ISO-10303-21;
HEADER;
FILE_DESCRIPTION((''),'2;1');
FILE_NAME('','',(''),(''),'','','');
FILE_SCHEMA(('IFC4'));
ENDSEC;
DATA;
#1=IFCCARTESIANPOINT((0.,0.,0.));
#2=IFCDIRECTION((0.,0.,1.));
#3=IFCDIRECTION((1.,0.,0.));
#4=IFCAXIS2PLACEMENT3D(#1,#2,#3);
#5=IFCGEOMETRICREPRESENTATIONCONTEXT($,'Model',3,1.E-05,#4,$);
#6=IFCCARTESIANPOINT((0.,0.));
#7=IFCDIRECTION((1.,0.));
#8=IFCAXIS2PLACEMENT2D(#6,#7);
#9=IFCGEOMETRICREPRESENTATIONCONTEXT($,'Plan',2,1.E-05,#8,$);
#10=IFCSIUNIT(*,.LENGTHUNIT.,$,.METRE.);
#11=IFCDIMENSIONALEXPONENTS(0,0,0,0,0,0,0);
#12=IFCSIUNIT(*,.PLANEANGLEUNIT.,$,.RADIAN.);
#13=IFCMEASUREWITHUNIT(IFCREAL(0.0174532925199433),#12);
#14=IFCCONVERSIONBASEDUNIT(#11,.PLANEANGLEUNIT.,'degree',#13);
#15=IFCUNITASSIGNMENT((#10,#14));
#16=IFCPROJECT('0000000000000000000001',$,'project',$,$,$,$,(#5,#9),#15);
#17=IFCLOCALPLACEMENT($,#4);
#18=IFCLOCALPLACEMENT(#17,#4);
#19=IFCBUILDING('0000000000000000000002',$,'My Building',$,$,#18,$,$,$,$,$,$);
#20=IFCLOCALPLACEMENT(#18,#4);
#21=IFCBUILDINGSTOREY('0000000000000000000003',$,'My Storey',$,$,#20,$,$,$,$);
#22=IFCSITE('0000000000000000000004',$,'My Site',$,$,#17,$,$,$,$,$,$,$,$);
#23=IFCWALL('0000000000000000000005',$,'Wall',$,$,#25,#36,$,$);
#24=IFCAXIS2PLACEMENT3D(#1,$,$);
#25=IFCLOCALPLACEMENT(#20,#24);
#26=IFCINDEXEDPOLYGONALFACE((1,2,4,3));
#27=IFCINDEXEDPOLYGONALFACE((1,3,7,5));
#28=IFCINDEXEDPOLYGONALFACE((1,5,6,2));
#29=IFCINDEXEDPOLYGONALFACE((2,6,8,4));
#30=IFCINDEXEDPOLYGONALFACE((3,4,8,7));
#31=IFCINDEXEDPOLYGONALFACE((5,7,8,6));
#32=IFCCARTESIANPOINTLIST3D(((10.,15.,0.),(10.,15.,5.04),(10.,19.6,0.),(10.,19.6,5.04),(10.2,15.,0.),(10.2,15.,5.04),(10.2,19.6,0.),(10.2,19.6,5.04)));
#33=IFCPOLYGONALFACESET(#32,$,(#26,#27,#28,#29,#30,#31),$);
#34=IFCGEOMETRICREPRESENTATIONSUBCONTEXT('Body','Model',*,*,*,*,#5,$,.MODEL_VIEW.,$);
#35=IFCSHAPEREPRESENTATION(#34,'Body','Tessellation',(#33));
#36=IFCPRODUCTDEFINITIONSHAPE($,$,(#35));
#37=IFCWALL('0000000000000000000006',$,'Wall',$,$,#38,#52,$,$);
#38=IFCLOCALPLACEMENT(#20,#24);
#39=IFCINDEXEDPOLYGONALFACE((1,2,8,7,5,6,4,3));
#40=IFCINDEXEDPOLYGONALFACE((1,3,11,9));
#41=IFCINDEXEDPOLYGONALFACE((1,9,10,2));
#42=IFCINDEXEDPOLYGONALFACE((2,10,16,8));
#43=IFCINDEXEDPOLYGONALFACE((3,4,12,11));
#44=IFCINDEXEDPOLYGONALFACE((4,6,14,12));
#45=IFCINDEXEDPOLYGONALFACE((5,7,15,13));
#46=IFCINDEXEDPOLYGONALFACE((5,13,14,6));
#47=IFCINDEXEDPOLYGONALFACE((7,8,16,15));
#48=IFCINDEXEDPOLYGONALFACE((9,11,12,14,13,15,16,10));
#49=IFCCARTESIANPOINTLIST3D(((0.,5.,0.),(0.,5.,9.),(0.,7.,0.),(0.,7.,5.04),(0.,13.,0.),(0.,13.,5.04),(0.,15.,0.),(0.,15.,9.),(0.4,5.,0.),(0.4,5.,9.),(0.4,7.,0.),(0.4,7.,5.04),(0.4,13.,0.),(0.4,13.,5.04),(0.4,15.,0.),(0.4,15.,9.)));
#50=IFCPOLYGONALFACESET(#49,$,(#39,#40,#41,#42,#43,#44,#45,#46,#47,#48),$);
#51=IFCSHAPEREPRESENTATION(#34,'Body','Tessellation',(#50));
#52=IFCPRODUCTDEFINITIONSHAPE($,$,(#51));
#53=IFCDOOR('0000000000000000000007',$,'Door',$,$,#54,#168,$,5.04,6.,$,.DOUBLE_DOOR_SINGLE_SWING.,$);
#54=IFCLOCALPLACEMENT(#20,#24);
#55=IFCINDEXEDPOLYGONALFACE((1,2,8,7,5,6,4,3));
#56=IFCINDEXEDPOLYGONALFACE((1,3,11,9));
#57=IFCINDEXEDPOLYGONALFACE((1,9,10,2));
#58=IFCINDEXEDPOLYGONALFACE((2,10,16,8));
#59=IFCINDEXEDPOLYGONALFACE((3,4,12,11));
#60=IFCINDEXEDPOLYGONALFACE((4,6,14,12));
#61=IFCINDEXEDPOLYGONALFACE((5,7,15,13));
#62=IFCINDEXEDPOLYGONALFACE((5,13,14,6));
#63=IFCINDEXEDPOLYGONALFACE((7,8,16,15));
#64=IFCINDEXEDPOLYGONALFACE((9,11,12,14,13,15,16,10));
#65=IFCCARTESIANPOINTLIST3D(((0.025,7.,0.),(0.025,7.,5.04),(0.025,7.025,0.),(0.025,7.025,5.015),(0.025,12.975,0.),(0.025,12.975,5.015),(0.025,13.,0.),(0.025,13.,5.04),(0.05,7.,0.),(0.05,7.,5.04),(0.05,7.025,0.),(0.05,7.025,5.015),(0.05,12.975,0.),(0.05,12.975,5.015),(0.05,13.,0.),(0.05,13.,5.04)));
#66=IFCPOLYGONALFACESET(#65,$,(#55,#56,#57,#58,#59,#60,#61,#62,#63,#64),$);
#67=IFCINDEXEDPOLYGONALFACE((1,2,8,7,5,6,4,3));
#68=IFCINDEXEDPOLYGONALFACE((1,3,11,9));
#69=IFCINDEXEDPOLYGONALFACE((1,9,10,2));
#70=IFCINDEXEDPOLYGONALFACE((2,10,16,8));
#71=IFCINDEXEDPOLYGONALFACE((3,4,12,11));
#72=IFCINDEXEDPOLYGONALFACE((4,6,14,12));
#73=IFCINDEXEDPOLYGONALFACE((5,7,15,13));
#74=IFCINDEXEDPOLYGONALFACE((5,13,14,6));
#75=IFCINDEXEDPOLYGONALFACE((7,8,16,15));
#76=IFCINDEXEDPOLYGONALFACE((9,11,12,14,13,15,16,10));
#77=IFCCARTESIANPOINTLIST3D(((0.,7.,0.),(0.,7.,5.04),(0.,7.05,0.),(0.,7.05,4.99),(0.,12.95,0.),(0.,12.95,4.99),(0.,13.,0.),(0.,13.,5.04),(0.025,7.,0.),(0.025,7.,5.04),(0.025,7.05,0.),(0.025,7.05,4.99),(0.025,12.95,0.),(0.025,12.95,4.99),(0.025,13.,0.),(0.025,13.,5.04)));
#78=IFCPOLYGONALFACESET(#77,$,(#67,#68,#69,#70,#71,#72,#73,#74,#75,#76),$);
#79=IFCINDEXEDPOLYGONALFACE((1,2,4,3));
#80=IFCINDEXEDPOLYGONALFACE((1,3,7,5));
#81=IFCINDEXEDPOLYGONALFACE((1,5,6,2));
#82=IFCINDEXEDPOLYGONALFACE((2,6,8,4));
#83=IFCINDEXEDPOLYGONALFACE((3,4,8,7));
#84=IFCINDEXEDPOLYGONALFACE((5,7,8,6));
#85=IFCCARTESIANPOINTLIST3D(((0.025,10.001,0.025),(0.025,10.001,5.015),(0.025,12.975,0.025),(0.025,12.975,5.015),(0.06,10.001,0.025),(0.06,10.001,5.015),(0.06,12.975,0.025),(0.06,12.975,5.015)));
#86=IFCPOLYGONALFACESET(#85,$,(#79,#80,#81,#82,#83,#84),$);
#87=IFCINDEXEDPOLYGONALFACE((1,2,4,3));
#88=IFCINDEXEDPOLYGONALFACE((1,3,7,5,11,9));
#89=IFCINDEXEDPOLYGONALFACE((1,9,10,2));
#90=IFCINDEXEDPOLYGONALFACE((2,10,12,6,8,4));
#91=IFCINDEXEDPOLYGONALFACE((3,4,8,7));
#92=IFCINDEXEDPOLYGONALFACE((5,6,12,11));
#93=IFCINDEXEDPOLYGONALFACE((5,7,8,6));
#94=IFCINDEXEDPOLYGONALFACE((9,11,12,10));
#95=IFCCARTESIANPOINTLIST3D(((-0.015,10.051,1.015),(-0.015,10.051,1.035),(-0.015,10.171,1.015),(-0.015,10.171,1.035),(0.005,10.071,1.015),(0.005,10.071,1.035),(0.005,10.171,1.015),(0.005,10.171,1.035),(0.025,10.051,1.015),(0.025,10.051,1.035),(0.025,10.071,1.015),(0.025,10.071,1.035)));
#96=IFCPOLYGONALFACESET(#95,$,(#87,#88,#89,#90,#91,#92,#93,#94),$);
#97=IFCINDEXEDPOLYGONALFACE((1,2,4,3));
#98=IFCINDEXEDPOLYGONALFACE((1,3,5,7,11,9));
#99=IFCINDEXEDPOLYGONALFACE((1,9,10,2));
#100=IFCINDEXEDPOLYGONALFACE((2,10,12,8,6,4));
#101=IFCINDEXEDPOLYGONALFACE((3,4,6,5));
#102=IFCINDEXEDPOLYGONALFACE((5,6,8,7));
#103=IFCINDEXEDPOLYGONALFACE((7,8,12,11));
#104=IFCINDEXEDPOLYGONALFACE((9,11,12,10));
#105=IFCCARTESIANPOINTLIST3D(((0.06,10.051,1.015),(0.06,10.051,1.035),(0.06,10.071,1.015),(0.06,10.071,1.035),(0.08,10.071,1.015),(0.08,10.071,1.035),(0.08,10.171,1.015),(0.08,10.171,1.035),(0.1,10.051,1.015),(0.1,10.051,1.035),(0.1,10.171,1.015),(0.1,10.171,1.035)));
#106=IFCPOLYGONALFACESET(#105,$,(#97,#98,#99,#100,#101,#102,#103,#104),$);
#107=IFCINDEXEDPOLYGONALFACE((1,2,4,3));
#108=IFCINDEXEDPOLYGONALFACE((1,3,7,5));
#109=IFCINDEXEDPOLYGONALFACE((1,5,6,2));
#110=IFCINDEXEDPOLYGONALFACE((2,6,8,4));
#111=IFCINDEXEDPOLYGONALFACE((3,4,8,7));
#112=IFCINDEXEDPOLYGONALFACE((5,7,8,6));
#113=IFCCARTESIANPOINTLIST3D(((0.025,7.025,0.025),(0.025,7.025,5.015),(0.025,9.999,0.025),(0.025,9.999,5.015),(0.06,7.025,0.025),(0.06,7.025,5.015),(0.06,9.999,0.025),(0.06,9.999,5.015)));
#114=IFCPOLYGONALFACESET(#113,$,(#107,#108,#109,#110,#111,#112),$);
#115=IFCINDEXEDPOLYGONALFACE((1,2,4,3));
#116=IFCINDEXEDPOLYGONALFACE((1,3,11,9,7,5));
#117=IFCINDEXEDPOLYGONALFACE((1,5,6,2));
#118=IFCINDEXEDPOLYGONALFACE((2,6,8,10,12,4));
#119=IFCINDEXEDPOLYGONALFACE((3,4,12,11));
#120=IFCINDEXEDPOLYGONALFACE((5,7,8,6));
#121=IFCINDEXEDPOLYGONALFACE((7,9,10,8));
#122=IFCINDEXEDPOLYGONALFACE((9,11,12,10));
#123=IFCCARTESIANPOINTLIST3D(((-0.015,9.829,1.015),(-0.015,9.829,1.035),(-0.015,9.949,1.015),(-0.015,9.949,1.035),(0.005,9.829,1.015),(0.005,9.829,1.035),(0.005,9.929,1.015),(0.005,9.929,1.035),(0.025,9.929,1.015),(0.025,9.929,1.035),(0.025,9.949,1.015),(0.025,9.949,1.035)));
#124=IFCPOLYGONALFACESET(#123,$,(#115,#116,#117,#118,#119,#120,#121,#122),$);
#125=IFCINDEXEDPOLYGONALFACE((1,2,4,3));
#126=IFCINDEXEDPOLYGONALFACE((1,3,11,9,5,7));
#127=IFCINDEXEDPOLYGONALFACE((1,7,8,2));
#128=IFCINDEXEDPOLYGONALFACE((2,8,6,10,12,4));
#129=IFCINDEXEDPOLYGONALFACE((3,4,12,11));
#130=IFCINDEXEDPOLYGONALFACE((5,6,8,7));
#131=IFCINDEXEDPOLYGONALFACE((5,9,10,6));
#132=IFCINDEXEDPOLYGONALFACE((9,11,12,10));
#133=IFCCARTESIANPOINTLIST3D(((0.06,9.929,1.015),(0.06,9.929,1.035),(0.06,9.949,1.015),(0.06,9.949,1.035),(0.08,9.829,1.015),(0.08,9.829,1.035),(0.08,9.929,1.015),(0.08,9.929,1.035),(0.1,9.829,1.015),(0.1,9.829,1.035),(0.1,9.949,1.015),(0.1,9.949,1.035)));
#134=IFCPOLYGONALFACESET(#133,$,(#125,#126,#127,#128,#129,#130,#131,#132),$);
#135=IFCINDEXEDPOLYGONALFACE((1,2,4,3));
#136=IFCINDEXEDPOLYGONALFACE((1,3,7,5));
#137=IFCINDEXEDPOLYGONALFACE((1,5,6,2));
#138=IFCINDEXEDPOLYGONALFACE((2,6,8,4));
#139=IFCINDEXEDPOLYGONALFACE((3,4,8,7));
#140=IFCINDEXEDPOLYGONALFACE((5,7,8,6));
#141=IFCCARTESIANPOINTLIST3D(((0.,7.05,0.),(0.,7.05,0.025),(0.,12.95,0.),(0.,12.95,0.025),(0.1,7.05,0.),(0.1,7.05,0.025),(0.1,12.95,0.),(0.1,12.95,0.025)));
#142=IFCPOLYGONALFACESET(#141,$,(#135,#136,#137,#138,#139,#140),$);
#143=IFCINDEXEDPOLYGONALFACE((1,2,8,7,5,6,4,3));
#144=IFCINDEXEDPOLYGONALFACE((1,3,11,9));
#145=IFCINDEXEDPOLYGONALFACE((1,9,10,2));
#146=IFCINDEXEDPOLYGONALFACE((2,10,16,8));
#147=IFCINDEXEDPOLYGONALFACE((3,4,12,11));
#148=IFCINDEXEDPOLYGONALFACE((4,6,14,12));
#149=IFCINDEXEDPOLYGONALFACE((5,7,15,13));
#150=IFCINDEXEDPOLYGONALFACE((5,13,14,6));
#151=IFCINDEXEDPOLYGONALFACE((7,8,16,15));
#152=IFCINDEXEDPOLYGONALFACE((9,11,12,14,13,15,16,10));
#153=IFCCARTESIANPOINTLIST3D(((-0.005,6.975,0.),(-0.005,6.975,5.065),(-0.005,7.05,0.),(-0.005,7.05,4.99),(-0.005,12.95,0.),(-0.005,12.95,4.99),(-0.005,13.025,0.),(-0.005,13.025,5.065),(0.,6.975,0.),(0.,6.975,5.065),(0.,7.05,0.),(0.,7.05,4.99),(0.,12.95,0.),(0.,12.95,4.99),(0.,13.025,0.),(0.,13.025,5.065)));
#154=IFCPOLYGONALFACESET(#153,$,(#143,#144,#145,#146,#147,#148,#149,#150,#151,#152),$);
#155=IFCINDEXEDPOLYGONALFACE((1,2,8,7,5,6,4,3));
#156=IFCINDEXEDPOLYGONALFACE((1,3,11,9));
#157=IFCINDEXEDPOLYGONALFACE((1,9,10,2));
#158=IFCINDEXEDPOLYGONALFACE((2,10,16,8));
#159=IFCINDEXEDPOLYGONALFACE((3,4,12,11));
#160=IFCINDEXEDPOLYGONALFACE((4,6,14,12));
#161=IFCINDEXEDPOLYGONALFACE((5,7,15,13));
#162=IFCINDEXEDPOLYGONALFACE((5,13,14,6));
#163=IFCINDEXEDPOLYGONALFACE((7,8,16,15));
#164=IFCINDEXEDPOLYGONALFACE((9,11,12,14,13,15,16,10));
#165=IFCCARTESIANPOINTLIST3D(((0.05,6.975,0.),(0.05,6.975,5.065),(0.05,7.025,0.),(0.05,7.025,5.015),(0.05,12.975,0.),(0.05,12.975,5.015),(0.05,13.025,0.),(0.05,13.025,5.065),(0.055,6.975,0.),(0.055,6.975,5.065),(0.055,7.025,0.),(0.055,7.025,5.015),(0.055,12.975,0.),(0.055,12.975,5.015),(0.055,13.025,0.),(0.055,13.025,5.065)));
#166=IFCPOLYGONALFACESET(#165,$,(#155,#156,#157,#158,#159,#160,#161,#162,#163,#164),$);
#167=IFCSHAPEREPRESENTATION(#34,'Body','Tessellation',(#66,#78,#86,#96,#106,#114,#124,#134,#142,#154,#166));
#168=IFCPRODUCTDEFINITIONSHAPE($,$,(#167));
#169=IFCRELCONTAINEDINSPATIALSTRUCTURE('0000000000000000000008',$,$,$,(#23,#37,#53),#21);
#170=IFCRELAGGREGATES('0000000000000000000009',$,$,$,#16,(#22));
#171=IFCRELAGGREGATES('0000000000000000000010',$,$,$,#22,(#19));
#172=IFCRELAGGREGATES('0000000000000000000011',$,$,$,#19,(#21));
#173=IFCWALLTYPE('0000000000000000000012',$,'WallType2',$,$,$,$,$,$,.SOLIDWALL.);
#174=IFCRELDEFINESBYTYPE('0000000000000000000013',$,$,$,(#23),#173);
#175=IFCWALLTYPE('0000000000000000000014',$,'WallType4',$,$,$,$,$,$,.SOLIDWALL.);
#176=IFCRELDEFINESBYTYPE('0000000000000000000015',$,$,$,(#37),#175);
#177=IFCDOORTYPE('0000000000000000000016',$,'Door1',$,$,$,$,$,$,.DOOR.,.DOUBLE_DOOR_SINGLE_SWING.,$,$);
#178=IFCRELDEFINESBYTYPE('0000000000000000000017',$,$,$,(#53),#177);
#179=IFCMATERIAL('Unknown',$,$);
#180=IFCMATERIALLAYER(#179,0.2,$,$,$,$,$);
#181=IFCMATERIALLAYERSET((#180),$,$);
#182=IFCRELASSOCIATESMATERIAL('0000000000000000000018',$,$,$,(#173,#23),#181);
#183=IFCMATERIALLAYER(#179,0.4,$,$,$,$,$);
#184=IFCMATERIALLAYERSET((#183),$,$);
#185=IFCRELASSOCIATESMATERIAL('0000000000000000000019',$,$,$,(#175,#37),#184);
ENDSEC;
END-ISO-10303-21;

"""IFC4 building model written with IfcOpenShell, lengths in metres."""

from ifc_helpers import new_model, entity, si_unit, converted_unit, frame, origin_with_axes, origin_2d_with_axis, place, context, subcontext, project, spatial, line, indexed_curve, outline, extrude, shape, source, transform, mapped, material, layer, layer_set, layer_usage, type_object, type_shapes, element, fill, save


model = new_model("IFC4")

# Units and contexts
model_context = context("Model", 3, precision=1e-05, world=origin_with_axes())
plan_context = context("Plan", 2, precision=1e-05, world=origin_2d_with_axis())
body_context_1 = subcontext(model_context, "Body", "Model", "MODEL_VIEW")
body_context_2 = subcontext(plan_context, "Body", "Plan", "PLAN_VIEW")
ifc_project = project(units=[si_unit("LENGTHUNIT", "METRE"), converted_unit("PLANEANGLEUNIT", "degree", entity("IfcReal", 0.0174532925199433), si_unit("PLANEANGLEUNIT", "RADIAN"), dimensions=[0, 0, 0, 0, 0, 0, 0])], contexts=[model_context, plan_context])

# Site, building, storey
site_placement = place(None, origin_with_axes())
site = spatial("IfcSite", under=ifc_project, at=site_placement, Name="My Site")
building_placement = place(site_placement, origin_with_axes())
building = spatial("IfcBuilding", under=site, at=building_placement, Name="My Building")
storey_placement = place(building_placement, origin_with_axes())
storey = spatial("IfcBuildingStorey", under=building, at=storey_placement, Name="My Storey")

# Wall
ifc_material = material(Name="Unknown")
ifc_layer_1 = layer(ifc_material, 0.2)
ifc_layer_set_1 = layer_set([ifc_layer_1])
ifc_layer_usage_1 = layer_usage(ifc_layer_set_1, "AXIS2", "POSITIVE", 0.0)
wall_type_1 = type_object("IfcWallType", Name="WallType2", PredefinedType="SOLIDWALL", material=ifc_layer_set_1)
wall_1_placement = place(storey_placement, frame((10.2, 15.0, 0.0), z_axis=(0.0, 0.0, 1.0), x_axis=(0.0, 1.0, 0.0)))
element("IfcWall", 1, at=wall_1_placement, inside=storey, type_object=wall_type_1, material=ifc_layer_usage_1, Name="Wall", context=body_context_1, shape_type="SweptSolid", body=[
    extrude(outline(indexed_curve([(0.0, 0.0), (0.0, 0.2), (4.6, 0.2), (4.6, 0.0), (0.0, 0.0)], self_intersect=False)), origin_with_axes(), (0.0, 0.0, 1.0), 5.04),
])

# Shared definitions
ifc_layer_2 = layer(ifc_material, 0.4)
ifc_layer_set_2 = layer_set([ifc_layer_2])
wall_type_2 = type_object("IfcWallType", Name="WallType4", PredefinedType="SOLIDWALL", material=ifc_layer_set_2)

# Wall, opening, door
ifc_layer_usage_2 = layer_usage(ifc_layer_set_2, "AXIS2", "POSITIVE", 0.0)
wall_2_placement = place(storey_placement, frame((0.0, 15.0, 0.0), z_axis=(0.0, 0.0, 1.0), x_axis=(0.0, -1.0, 0.0)))
wall_2 = element("IfcWall", 2, at=wall_2_placement, inside=storey, type_object=wall_type_2, material=ifc_layer_usage_2, Name="Wall", context=body_context_1, shape_type="SweptSolid", body=[
    extrude(outline(indexed_curve([(0.0, 0.0), (0.0, 0.4), (10.0, 0.4), (10.0, 0.0), (0.0, 0.0)], self_intersect=False)), origin_with_axes(), (0.0, 0.0, 1.0), 9.0),
])
shared_shape_1 = source(origin_with_axes(), body_context_1, "Body", "SweptSolid", [
    extrude(outline(indexed_curve([(0.0, 0.0), (6.0, 0.0), (6.0, 5.04), (0.0, 5.04)], segments=[line(1, 2, 3, 4, 1)])), frame((0.0, -0.1, 0.0), z_axis=(0.0, -1.0, 0.0), x_axis=(1.0, 0.0, 0.0)), (0.0, 0.0, -1.0), 0.6),
])
opening_1_placement = place(wall_2_placement, frame((2.0, 0.0, 0.0), z_axis=(0.0, 0.0, 1.0), x_axis=(1.0, 0.0, 0.0)))
opening_1 = element("IfcOpeningElement", 3, at=opening_1_placement, cuts=wall_2, PredefinedType="OPENING", context=body_context_1, shape_type="MappedRepresentation", body=[
    mapped(shared_shape_1, transform((0.0, 0.0, 0.0), x_axis=(1.0, 0.0, 0.0), y_axis=(0.0, 1.0, 0.0), z_axis=(0.0, 0.0, 1.0), scale=1.0)),
])
door_type_1 = type_object("IfcDoorType", Name="Door1", OperationType="DOUBLE_DOOR_SINGLE_SWING", PredefinedType="DOOR")
shared_shape_2 = source(origin_with_axes(), body_context_1, "Body", "SweptSolid", [
    extrude(outline(indexed_curve([(0.0, 0.0), (0.0, 5.04), (6.0, 5.04), (6.0, 0.0), (5.975, 0.0), (5.975, 5.015), (0.025, 5.015), (0.025, 0.0)], segments=[line(1, 2, 3, 4, 5, 6, 7, 8, 1)])), frame((0.0, 0.025, 0.0), z_axis=(0.0, -1.0, 0.0), x_axis=(1.0, 0.0, 0.0)), (0.0, 0.0, -1.0), 0.025),
    extrude(outline(indexed_curve([(0.0, 0.0), (0.0, 5.04), (6.0, 5.04), (6.0, 0.0), (5.95, 0.0), (5.95, 4.99), (0.05, 4.99), (0.05, 0.0)], segments=[line(1, 2, 3, 4, 5, 6, 7, 8, 1)])), frame((0.0, 0.0, 0.0), z_axis=(0.0, -1.0, 0.0), x_axis=(1.0, 0.0, 0.0)), (0.0, 0.0, -1.0), 0.025),
    extrude(outline(indexed_curve([(0.0, 0.0), (2.974, 0.0), (2.974, 0.035), (0.0, 0.035)], segments=[line(1, 2, 3, 4, 1)])), frame((0.025, 0.025, 0.025), z_axis=(0.0, 0.0, 1.0), x_axis=(1.0, 0.0, 0.0)), (0.0, 0.0, 1.0), 4.99),
    extrude(outline(indexed_curve([(0.0, 0.0), (0.0, -0.04), (-0.12, -0.04), (-0.12, -0.02), (-0.02, -0.02), (-0.02, 0.0)], segments=[line(1, 2, 3, 4, 5, 6, 1)])), frame((2.949, 0.025, 1.015), z_axis=(0.0, 0.0, 1.0), x_axis=(1.0, 0.0, 0.0)), (0.0, 0.0, 1.0), 0.02),
    extrude(outline(indexed_curve([(0.0, 0.0), (0.0, 0.04), (-0.12, 0.04), (-0.12, 0.02), (-0.02, 0.02), (-0.02, 0.0)], segments=[line(1, 2, 3, 4, 5, 6, 1)])), frame((2.949, 0.06, 1.015), z_axis=(0.0, 0.0, 1.0), x_axis=(1.0, 0.0, 0.0)), (0.0, 0.0, 1.0), 0.02),
    extrude(outline(indexed_curve([(0.0, 0.0), (-2.974, 0.0), (-2.974, 0.035), (0.0, 0.035)], segments=[line(1, 2, 3, 4, 1)])), frame((5.975, 0.025, 0.025), z_axis=(0.0, 0.0, 1.0), x_axis=(1.0, 0.0, 0.0)), (0.0, 0.0, 1.0), 4.99),
    extrude(outline(indexed_curve([(0.0, 0.0), (0.0, -0.04), (0.12, -0.04), (0.12, -0.02), (0.02, -0.02), (0.02, 0.0)], segments=[line(1, 2, 3, 4, 5, 6, 1)])), frame((3.051, 0.025, 1.015), z_axis=(0.0, 0.0, 1.0), x_axis=(1.0, 0.0, 0.0)), (0.0, 0.0, 1.0), 0.02),
    extrude(outline(indexed_curve([(0.0, 0.0), (0.0, 0.04), (0.12, 0.04), (0.12, 0.02), (0.02, 0.02), (0.02, 0.0)], segments=[line(1, 2, 3, 4, 5, 6, 1)])), frame((3.051, 0.06, 1.015), z_axis=(0.0, 0.0, 1.0), x_axis=(1.0, 0.0, 0.0)), (0.0, 0.0, 1.0), 0.02),
    extrude(outline(indexed_curve([(0.0, 0.0), (5.9, 0.0), (5.9, 0.1), (0.0, 0.1)], segments=[line(1, 2, 3, 4, 1)])), frame((0.05, 0.0, 0.0), z_axis=(0.0, 0.0, 1.0), x_axis=(1.0, 0.0, 0.0)), (0.0, 0.0, 1.0), 0.025),
    extrude(outline(indexed_curve([(0.0, 0.0), (0.0, 5.065), (6.05, 5.065), (6.05, 0.0), (5.975, 0.0), (5.975, 4.99), (0.075, 4.99), (0.075, 0.0)], segments=[line(1, 2, 3, 4, 5, 6, 7, 8, 1)])), frame((-0.025, -0.005, 0.0), z_axis=(0.0, -1.0, 0.0), x_axis=(1.0, 0.0, 0.0)), (0.0, 0.0, -1.0), 0.005),
    extrude(outline(indexed_curve([(0.0, 0.0), (0.0, 5.065), (6.05, 5.065), (6.05, 0.0), (6.0, 0.0), (6.0, 5.015), (0.05, 5.015), (0.05, 0.0)], segments=[line(1, 2, 3, 4, 5, 6, 7, 8, 1)])), frame((-0.025, 0.05, 0.0), z_axis=(0.0, -1.0, 0.0), x_axis=(1.0, 0.0, 0.0)), (0.0, 0.0, -1.0), 0.005),
])
shared_shape_3 = source(origin_with_axes(), body_context_2, "Body", "Curve2D", [
    entity("IfcIndexedPolyCurve", entity("IfcCartesianPointList2D", [[0.0, 0.0], [0.0, 0.05], [0.025, 0.05], [0.025, 0.025], [0.05, 0.025], [0.05, 0.0]]), [entity("IfcLineIndex", [1, 2, 3, 4, 5, 6, 1])]),
    entity("IfcIndexedPolyCurve", entity("IfcCartesianPointList2D", [[6.0, 0.0], [6.0, 0.05], [5.975, 0.05], [5.975, 0.025], [5.95, 0.025], [5.95, 0.0]]), [entity("IfcLineIndex", [1, 2, 3, 4, 5, 6, 1])]),
    entity("IfcTrimmedCurve", entity("IfcEllipse", entity("IfcAxis2Placement2D", entity("IfcCartesianPoint", [0.06, 0.05]), entity("IfcDirection", [1.0, 0.0])), 2.94, 2.975), [entity("IfcCartesianPoint", [3.0, 0.05])], [entity("IfcCartesianPoint", [0.06, 3.025])], True, "CARTESIAN"),
    entity("IfcIndexedPolyCurve", entity("IfcCartesianPointList2D", [[0.025, 0.05], [0.06, 0.05], [0.06, 3.025], [0.025, 3.025]]), [entity("IfcLineIndex", [1, 2, 3, 4, 1])]),
    entity("IfcTrimmedCurve", entity("IfcEllipse", entity("IfcAxis2Placement2D", entity("IfcCartesianPoint", [5.94, 0.05]), entity("IfcDirection", [1.0, 0.0])), 2.94, 2.975), [entity("IfcCartesianPoint", [5.94, 3.025])], [entity("IfcCartesianPoint", [3.0, 0.05])], True, "CARTESIAN"),
    entity("IfcIndexedPolyCurve", entity("IfcCartesianPointList2D", [[5.975, 0.05], [5.94, 0.05], [5.94, 3.025], [5.975, 3.025]]), [entity("IfcLineIndex", [1, 2, 3, 4, 1])]),
])
type_shapes(door_type_1, [shared_shape_2, shared_shape_3])
door_1_placement = place(opening_1_placement, frame((0.0, 0.0, 0.0), z_axis=(0.0, 0.0, 1.0), x_axis=(1.0, 0.0, 0.0)))
door_1 = element("IfcDoor", 4, at=door_1_placement, inside=storey, type_object=door_type_1, Name="Door", OperationType="DOUBLE_DOOR_SINGLE_SWING", OverallHeight=5.04, OverallWidth=6.0, shapes=[
    shape(body_context_1, "Body", "MappedRepresentation", [mapped(shared_shape_2, transform((0.0, 0.0, 0.0), x_axis=(1.0, 0.0, 0.0), y_axis=(0.0, 1.0, 0.0), z_axis=(0.0, 0.0, 1.0), scale=1.0))]),
    shape(body_context_2, "Body", "MappedRepresentation", [mapped(shared_shape_3, transform((0.0, 0.0, 0.0), x_axis=(1.0, 0.0, 0.0), y_axis=(0.0, 1.0, 0.0), z_axis=(0.0, 0.0, 1.0), scale=1.0))]),
])
fill(opening_1, door_1)

save(model, "model.ifc")
